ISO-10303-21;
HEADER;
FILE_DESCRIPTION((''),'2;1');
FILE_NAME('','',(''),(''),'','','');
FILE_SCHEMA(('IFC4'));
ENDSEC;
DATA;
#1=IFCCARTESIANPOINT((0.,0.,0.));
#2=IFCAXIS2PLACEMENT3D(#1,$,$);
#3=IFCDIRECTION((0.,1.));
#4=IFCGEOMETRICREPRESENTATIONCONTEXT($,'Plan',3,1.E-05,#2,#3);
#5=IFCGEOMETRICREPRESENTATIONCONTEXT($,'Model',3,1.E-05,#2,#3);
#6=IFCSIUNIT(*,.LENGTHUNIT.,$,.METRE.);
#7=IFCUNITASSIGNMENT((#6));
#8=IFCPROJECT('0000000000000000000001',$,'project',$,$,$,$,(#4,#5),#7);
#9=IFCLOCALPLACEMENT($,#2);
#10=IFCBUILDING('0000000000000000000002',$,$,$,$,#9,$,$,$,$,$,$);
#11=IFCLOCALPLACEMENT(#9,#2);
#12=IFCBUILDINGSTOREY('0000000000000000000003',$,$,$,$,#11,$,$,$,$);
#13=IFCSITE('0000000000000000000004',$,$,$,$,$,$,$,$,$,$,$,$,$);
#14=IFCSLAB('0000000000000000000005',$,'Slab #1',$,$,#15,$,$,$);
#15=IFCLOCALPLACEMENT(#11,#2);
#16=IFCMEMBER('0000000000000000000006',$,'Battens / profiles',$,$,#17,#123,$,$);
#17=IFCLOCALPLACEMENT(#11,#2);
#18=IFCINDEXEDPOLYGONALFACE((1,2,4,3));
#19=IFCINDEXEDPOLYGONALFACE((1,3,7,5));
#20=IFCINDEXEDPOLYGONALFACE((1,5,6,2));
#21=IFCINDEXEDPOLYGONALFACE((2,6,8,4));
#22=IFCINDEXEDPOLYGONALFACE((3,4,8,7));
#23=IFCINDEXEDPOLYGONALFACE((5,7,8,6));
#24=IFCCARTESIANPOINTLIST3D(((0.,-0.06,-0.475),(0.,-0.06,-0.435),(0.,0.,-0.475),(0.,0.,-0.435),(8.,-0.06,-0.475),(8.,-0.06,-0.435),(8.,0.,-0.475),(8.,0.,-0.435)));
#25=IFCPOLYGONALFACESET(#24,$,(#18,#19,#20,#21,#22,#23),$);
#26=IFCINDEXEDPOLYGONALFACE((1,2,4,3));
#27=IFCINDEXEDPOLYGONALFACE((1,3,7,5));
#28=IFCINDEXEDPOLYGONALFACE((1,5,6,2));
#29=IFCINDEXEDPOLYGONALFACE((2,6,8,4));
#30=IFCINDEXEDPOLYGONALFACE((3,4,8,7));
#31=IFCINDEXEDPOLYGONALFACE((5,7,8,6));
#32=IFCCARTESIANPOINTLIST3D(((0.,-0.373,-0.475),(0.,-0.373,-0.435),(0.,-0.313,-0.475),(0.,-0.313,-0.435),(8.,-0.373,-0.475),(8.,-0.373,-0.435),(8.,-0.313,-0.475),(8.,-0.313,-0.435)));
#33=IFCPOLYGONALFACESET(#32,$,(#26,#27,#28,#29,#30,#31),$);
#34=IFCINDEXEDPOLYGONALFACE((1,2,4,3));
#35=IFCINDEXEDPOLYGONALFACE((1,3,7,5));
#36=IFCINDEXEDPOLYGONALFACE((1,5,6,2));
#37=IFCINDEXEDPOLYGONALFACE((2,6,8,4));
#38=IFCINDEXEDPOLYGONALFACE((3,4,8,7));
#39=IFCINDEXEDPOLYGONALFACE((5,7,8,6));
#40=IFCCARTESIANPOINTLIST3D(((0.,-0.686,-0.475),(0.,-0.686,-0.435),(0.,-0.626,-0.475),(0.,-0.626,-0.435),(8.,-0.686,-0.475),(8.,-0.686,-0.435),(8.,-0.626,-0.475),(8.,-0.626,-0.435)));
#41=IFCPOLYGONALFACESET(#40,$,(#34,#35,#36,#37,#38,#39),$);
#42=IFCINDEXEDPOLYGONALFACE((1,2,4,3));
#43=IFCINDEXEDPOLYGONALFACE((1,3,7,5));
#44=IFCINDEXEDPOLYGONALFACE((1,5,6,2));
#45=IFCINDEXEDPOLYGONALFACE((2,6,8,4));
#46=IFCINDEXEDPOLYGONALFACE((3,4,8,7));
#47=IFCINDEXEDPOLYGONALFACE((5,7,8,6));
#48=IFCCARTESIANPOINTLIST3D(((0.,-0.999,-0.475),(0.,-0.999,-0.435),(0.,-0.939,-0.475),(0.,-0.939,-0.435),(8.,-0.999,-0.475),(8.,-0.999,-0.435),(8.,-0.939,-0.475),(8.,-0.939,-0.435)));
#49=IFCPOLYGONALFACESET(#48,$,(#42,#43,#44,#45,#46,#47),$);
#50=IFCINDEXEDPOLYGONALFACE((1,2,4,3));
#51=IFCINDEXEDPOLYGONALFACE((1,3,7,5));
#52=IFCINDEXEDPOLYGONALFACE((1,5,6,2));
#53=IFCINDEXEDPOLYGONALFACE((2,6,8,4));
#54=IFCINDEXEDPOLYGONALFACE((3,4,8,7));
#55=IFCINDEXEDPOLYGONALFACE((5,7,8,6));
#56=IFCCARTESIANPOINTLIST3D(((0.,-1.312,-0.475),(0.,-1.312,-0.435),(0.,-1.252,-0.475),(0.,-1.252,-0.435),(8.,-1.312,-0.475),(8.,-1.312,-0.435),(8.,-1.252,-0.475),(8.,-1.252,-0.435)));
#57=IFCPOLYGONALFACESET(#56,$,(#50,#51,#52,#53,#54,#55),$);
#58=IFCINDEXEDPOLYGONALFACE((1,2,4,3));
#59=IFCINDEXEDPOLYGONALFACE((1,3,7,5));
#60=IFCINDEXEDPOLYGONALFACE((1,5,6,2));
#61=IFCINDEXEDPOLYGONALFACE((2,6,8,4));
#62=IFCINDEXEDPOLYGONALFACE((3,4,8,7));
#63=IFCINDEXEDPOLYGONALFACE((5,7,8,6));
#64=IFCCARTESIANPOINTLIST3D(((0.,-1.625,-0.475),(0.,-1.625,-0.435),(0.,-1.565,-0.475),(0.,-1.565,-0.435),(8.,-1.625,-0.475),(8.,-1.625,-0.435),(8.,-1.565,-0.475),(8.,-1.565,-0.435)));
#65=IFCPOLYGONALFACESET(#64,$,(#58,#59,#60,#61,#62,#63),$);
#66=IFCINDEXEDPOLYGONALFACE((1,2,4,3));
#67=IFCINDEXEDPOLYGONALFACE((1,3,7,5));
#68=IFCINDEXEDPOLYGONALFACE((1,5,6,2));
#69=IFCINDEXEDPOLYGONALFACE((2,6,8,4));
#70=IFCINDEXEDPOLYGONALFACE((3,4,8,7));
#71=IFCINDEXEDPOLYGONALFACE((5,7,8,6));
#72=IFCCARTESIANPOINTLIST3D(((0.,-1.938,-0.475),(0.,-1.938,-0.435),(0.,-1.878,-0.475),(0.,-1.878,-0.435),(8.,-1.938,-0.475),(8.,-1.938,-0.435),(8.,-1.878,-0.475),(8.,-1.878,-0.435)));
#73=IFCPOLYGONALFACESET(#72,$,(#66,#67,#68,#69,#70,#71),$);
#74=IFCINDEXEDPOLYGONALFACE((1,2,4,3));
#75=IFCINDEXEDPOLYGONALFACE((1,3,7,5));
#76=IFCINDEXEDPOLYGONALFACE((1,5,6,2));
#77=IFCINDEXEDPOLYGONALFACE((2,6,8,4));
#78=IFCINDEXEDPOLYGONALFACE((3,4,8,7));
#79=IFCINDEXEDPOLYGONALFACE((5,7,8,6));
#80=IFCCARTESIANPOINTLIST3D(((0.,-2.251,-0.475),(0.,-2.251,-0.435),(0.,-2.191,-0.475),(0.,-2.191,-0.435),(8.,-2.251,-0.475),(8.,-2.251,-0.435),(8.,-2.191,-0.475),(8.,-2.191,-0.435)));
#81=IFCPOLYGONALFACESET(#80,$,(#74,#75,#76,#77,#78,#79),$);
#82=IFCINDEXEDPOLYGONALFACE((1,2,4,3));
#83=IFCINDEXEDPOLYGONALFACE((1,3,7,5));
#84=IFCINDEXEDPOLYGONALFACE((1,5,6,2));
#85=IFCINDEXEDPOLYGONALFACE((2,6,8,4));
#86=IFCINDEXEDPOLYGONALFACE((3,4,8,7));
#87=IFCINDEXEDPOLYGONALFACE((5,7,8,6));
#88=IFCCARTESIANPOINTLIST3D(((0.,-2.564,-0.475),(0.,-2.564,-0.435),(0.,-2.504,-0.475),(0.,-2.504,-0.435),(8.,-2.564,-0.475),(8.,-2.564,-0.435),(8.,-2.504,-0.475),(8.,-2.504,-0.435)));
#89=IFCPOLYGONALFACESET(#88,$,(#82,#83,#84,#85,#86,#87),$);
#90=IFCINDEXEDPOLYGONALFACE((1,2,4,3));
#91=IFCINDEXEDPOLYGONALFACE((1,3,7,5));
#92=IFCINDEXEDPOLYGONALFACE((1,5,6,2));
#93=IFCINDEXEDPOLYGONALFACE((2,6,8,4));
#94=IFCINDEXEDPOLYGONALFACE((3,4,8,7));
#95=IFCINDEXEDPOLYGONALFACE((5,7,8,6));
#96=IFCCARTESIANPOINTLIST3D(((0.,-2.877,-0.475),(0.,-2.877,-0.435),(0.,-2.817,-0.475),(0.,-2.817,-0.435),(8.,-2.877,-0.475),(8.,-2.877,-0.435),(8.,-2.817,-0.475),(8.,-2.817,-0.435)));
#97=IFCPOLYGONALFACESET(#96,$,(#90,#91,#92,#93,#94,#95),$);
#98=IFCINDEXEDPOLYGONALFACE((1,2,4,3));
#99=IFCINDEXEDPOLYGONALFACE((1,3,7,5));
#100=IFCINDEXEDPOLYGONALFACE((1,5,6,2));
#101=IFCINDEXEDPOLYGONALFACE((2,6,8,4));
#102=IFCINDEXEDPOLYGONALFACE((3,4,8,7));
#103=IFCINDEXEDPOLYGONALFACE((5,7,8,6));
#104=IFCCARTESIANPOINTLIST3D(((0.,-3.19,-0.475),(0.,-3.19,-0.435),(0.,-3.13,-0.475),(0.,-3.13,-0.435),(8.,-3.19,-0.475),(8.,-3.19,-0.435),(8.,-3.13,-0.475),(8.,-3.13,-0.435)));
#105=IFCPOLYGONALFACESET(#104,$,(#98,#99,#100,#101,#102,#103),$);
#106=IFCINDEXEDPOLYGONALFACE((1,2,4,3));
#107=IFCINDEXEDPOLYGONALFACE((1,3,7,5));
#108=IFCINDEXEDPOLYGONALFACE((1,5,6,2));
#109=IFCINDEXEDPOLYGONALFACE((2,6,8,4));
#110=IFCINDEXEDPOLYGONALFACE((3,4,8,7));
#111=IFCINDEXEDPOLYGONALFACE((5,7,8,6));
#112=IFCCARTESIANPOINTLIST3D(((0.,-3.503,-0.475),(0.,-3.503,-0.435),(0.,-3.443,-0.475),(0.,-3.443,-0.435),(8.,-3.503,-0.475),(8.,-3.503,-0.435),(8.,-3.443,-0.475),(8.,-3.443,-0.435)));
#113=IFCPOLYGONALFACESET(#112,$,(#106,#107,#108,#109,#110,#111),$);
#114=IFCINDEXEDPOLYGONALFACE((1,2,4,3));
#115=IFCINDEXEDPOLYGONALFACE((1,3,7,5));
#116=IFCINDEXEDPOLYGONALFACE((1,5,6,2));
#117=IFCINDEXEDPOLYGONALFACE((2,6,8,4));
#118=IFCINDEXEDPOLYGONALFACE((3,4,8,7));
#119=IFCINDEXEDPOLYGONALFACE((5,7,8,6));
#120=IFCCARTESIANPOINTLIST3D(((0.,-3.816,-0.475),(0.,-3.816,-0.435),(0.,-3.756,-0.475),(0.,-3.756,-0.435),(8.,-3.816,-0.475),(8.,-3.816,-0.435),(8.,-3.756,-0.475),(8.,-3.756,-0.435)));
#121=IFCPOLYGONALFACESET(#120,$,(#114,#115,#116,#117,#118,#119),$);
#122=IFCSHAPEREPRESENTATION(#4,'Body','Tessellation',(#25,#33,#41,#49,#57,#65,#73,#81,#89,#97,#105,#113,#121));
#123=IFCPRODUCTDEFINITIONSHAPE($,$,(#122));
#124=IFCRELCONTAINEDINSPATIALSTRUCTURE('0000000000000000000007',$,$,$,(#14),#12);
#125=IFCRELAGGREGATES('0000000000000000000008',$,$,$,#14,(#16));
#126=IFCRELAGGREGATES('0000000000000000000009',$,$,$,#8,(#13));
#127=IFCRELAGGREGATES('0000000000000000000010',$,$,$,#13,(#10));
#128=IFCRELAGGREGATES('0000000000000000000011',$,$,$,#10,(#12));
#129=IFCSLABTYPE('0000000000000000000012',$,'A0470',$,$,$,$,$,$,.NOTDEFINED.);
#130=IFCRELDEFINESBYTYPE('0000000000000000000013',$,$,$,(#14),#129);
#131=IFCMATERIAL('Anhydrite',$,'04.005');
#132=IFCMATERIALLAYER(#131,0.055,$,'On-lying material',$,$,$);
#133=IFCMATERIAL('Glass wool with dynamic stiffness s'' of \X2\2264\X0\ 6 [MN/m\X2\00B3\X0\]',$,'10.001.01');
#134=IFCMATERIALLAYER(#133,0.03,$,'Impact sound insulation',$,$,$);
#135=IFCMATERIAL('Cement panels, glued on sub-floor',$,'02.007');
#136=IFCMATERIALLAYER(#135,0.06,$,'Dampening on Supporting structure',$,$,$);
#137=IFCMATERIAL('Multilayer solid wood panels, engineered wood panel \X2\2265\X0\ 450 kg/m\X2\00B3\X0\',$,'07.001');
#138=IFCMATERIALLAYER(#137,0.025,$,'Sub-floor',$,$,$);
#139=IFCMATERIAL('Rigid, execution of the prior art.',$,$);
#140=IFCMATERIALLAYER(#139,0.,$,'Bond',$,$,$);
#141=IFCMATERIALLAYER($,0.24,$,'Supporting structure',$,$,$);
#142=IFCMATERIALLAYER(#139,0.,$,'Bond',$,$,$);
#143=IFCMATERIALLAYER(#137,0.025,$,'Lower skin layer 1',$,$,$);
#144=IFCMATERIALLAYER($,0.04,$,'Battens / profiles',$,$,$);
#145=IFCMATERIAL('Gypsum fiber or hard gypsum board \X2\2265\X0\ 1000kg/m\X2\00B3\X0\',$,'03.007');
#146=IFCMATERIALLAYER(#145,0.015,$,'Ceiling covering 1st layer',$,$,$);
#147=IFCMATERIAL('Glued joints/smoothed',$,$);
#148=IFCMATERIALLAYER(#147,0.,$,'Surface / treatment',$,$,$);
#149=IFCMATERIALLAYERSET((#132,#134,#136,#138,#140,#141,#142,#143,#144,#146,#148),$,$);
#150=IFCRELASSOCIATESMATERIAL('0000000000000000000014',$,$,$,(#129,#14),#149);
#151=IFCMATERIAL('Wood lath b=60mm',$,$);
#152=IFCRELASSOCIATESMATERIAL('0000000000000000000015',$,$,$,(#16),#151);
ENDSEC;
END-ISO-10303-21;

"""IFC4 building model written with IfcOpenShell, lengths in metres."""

from ifc_helpers import new_model, si_unit, direction, frame, frame_2d, origin, place, context, project, spatial, rectangle, extrude, material, layer, layer_set, type_object, element, aggregate, save


model = new_model("IFC4")

# Units and contexts
plan_context = context("Plan", 3, precision=1e-05, world=origin(), true_north=direction((0.0, 1.0)))
model_context = context("Model", 3, precision=1e-05, world=origin(), true_north=direction((0.0, 1.0)))
ifc_project = project(units=[si_unit("LENGTHUNIT", "METRE")], contexts=[plan_context, model_context])

# Site, building, storey
site = spatial("IfcSite", under=ifc_project)
building_placement = place(None, origin())
building = spatial("IfcBuilding", under=site, at=building_placement)
storey_placement = place(building_placement, origin())
storey = spatial("IfcBuildingStorey", under=building, at=storey_placement)

# Slab, member
ifc_material_1 = material(Name="Anhydrite", Category="04.005")
ifc_layer_1 = layer(ifc_material_1, 0.055, Name="On-lying material")
ifc_material_2 = material(Name="Glass wool with dynamic stiffness s' of ≤ 6 [MN/m³]", Category="10.001.01")
ifc_layer_2 = layer(ifc_material_2, 0.03, Name="Impact sound insulation")
ifc_material_3 = material(Name="Cement panels, glued on sub-floor", Category="02.007")
ifc_layer_3 = layer(ifc_material_3, 0.06, Name="Dampening on Supporting structure")
ifc_material_4 = material(Name="Multilayer solid wood panels, engineered wood panel ≥ 450 kg/m³", Category="07.001")
ifc_layer_4 = layer(ifc_material_4, 0.025, Name="Sub-floor")
ifc_material_5 = material(Name="Rigid, execution of the prior art.")
ifc_layer_5 = layer(ifc_material_5, 0.0, Name="Bond")
ifc_layer_6 = layer(None, 0.24, Name="Supporting structure")
ifc_layer_7 = layer(ifc_material_5, 0.0, Name="Bond")
ifc_layer_8 = layer(ifc_material_4, 0.025, Name="Lower skin layer 1")
ifc_layer_9 = layer(None, 0.04, Name="Battens / profiles")
ifc_material_6 = material(Name="Gypsum fiber or hard gypsum board ≥ 1000kg/m³", Category="03.007")
ifc_layer_10 = layer(ifc_material_6, 0.015, Name="Ceiling covering 1st layer")
ifc_material_7 = material(Name="Glued joints/smoothed")
ifc_layer_11 = layer(ifc_material_7, 0.0, Name="Surface / treatment")
ifc_layer_set = layer_set([ifc_layer_1, ifc_layer_2, ifc_layer_3, ifc_layer_4, ifc_layer_5, ifc_layer_6, ifc_layer_7, ifc_layer_8, ifc_layer_9, ifc_layer_10, ifc_layer_11])
slab_type = type_object("IfcSlabType", Name="A0470", PredefinedType="NOTDEFINED", material=ifc_layer_set)
slab_placement = place(None, frame((0.0, 0.0, 0.0), z_axis=(0.0, 0.0, -1.0), x_axis=(1.0, 0.0, 0.0)))
slab = element("IfcSlab", 1, at=slab_placement, inside=storey, type_object=slab_type, material=ifc_layer_set, Name="Slab #1")
ifc_material_8 = material(Name="Wood lath b=60mm")
member_1_placement = place(slab_placement, origin())
member_1 = element("IfcMember", 2, at=member_1_placement, material=ifc_material_8, Name="Battens / profiles", context=plan_context, shape_type="SweptSolid", body=[
    extrude(rectangle(XDim=0.06, YDim=0.04, at=frame_2d((0.03, 0.02), x_axis=(1.0, 0.0))), frame((0.0, 0.0, 0.435), z_axis=(1.0, 0.0, 0.0), x_axis=(0.0, 1.0, 0.0)), (0.0, 0.0, 1.0), 8.0),
    extrude(rectangle(XDim=0.06, YDim=0.04, at=frame_2d((0.03, 0.02), x_axis=(1.0, 0.0))), frame((0.0, 0.313, 0.435), z_axis=(1.0, 0.0, 0.0), x_axis=(0.0, 1.0, 0.0)), (0.0, 0.0, 1.0), 8.0),
    extrude(rectangle(XDim=0.06, YDim=0.04, at=frame_2d((0.03, 0.02), x_axis=(1.0, 0.0))), frame((0.0, 0.626, 0.435), z_axis=(1.0, 0.0, 0.0), x_axis=(0.0, 1.0, 0.0)), (0.0, 0.0, 1.0), 8.0),
    extrude(rectangle(XDim=0.06, YDim=0.04, at=frame_2d((0.03, 0.02), x_axis=(1.0, 0.0))), frame((0.0, 0.939, 0.435), z_axis=(1.0, 0.0, 0.0), x_axis=(0.0, 1.0, 0.0)), (0.0, 0.0, 1.0), 8.0),
    extrude(rectangle(XDim=0.06, YDim=0.04, at=frame_2d((0.03, 0.02), x_axis=(1.0, 0.0))), frame((0.0, 1.252, 0.435), z_axis=(1.0, 0.0, 0.0), x_axis=(0.0, 1.0, 0.0)), (0.0, 0.0, 1.0), 8.0),
    extrude(rectangle(XDim=0.06, YDim=0.04, at=frame_2d((0.03, 0.02), x_axis=(1.0, 0.0))), frame((0.0, 1.565, 0.435), z_axis=(1.0, 0.0, 0.0), x_axis=(0.0, 1.0, 0.0)), (0.0, 0.0, 1.0), 8.0),
    extrude(rectangle(XDim=0.06, YDim=0.04, at=frame_2d((0.03, 0.02), x_axis=(1.0, 0.0))), frame((0.0, 1.878, 0.435), z_axis=(1.0, 0.0, 0.0), x_axis=(0.0, 1.0, 0.0)), (0.0, 0.0, 1.0), 8.0),
    extrude(rectangle(XDim=0.06, YDim=0.04, at=frame_2d((0.03, 0.02), x_axis=(1.0, 0.0))), frame((0.0, 2.191, 0.435), z_axis=(1.0, 0.0, 0.0), x_axis=(0.0, 1.0, 0.0)), (0.0, 0.0, 1.0), 8.0),
    extrude(rectangle(XDim=0.06, YDim=0.04, at=frame_2d((0.03, 0.02), x_axis=(1.0, 0.0))), frame((0.0, 2.504, 0.435), z_axis=(1.0, 0.0, 0.0), x_axis=(0.0, 1.0, 0.0)), (0.0, 0.0, 1.0), 8.0),
    extrude(rectangle(XDim=0.06, YDim=0.04, at=frame_2d((0.03, 0.02), x_axis=(1.0, 0.0))), frame((0.0, 2.817, 0.435), z_axis=(1.0, 0.0, 0.0), x_axis=(0.0, 1.0, 0.0)), (0.0, 0.0, 1.0), 8.0),
    extrude(rectangle(XDim=0.06, YDim=0.04, at=frame_2d((0.03, 0.02), x_axis=(1.0, 0.0))), frame((0.0, 3.13, 0.435), z_axis=(1.0, 0.0, 0.0), x_axis=(0.0, 1.0, 0.0)), (0.0, 0.0, 1.0), 8.0),
    extrude(rectangle(XDim=0.06, YDim=0.04, at=frame_2d((0.03, 0.02), x_axis=(1.0, 0.0))), frame((0.0, 3.443, 0.435), z_axis=(1.0, 0.0, 0.0), x_axis=(0.0, 1.0, 0.0)), (0.0, 0.0, 1.0), 8.0),
    extrude(rectangle(XDim=0.06, YDim=0.04, at=frame_2d((0.03, 0.02), x_axis=(1.0, 0.0))), frame((0.0, 3.756, 0.435), z_axis=(1.0, 0.0, 0.0), x_axis=(0.0, 1.0, 0.0)), (0.0, 0.0, 1.0), 8.0),
])
aggregate(slab, [member_1])

save(model, "model.ifc")
